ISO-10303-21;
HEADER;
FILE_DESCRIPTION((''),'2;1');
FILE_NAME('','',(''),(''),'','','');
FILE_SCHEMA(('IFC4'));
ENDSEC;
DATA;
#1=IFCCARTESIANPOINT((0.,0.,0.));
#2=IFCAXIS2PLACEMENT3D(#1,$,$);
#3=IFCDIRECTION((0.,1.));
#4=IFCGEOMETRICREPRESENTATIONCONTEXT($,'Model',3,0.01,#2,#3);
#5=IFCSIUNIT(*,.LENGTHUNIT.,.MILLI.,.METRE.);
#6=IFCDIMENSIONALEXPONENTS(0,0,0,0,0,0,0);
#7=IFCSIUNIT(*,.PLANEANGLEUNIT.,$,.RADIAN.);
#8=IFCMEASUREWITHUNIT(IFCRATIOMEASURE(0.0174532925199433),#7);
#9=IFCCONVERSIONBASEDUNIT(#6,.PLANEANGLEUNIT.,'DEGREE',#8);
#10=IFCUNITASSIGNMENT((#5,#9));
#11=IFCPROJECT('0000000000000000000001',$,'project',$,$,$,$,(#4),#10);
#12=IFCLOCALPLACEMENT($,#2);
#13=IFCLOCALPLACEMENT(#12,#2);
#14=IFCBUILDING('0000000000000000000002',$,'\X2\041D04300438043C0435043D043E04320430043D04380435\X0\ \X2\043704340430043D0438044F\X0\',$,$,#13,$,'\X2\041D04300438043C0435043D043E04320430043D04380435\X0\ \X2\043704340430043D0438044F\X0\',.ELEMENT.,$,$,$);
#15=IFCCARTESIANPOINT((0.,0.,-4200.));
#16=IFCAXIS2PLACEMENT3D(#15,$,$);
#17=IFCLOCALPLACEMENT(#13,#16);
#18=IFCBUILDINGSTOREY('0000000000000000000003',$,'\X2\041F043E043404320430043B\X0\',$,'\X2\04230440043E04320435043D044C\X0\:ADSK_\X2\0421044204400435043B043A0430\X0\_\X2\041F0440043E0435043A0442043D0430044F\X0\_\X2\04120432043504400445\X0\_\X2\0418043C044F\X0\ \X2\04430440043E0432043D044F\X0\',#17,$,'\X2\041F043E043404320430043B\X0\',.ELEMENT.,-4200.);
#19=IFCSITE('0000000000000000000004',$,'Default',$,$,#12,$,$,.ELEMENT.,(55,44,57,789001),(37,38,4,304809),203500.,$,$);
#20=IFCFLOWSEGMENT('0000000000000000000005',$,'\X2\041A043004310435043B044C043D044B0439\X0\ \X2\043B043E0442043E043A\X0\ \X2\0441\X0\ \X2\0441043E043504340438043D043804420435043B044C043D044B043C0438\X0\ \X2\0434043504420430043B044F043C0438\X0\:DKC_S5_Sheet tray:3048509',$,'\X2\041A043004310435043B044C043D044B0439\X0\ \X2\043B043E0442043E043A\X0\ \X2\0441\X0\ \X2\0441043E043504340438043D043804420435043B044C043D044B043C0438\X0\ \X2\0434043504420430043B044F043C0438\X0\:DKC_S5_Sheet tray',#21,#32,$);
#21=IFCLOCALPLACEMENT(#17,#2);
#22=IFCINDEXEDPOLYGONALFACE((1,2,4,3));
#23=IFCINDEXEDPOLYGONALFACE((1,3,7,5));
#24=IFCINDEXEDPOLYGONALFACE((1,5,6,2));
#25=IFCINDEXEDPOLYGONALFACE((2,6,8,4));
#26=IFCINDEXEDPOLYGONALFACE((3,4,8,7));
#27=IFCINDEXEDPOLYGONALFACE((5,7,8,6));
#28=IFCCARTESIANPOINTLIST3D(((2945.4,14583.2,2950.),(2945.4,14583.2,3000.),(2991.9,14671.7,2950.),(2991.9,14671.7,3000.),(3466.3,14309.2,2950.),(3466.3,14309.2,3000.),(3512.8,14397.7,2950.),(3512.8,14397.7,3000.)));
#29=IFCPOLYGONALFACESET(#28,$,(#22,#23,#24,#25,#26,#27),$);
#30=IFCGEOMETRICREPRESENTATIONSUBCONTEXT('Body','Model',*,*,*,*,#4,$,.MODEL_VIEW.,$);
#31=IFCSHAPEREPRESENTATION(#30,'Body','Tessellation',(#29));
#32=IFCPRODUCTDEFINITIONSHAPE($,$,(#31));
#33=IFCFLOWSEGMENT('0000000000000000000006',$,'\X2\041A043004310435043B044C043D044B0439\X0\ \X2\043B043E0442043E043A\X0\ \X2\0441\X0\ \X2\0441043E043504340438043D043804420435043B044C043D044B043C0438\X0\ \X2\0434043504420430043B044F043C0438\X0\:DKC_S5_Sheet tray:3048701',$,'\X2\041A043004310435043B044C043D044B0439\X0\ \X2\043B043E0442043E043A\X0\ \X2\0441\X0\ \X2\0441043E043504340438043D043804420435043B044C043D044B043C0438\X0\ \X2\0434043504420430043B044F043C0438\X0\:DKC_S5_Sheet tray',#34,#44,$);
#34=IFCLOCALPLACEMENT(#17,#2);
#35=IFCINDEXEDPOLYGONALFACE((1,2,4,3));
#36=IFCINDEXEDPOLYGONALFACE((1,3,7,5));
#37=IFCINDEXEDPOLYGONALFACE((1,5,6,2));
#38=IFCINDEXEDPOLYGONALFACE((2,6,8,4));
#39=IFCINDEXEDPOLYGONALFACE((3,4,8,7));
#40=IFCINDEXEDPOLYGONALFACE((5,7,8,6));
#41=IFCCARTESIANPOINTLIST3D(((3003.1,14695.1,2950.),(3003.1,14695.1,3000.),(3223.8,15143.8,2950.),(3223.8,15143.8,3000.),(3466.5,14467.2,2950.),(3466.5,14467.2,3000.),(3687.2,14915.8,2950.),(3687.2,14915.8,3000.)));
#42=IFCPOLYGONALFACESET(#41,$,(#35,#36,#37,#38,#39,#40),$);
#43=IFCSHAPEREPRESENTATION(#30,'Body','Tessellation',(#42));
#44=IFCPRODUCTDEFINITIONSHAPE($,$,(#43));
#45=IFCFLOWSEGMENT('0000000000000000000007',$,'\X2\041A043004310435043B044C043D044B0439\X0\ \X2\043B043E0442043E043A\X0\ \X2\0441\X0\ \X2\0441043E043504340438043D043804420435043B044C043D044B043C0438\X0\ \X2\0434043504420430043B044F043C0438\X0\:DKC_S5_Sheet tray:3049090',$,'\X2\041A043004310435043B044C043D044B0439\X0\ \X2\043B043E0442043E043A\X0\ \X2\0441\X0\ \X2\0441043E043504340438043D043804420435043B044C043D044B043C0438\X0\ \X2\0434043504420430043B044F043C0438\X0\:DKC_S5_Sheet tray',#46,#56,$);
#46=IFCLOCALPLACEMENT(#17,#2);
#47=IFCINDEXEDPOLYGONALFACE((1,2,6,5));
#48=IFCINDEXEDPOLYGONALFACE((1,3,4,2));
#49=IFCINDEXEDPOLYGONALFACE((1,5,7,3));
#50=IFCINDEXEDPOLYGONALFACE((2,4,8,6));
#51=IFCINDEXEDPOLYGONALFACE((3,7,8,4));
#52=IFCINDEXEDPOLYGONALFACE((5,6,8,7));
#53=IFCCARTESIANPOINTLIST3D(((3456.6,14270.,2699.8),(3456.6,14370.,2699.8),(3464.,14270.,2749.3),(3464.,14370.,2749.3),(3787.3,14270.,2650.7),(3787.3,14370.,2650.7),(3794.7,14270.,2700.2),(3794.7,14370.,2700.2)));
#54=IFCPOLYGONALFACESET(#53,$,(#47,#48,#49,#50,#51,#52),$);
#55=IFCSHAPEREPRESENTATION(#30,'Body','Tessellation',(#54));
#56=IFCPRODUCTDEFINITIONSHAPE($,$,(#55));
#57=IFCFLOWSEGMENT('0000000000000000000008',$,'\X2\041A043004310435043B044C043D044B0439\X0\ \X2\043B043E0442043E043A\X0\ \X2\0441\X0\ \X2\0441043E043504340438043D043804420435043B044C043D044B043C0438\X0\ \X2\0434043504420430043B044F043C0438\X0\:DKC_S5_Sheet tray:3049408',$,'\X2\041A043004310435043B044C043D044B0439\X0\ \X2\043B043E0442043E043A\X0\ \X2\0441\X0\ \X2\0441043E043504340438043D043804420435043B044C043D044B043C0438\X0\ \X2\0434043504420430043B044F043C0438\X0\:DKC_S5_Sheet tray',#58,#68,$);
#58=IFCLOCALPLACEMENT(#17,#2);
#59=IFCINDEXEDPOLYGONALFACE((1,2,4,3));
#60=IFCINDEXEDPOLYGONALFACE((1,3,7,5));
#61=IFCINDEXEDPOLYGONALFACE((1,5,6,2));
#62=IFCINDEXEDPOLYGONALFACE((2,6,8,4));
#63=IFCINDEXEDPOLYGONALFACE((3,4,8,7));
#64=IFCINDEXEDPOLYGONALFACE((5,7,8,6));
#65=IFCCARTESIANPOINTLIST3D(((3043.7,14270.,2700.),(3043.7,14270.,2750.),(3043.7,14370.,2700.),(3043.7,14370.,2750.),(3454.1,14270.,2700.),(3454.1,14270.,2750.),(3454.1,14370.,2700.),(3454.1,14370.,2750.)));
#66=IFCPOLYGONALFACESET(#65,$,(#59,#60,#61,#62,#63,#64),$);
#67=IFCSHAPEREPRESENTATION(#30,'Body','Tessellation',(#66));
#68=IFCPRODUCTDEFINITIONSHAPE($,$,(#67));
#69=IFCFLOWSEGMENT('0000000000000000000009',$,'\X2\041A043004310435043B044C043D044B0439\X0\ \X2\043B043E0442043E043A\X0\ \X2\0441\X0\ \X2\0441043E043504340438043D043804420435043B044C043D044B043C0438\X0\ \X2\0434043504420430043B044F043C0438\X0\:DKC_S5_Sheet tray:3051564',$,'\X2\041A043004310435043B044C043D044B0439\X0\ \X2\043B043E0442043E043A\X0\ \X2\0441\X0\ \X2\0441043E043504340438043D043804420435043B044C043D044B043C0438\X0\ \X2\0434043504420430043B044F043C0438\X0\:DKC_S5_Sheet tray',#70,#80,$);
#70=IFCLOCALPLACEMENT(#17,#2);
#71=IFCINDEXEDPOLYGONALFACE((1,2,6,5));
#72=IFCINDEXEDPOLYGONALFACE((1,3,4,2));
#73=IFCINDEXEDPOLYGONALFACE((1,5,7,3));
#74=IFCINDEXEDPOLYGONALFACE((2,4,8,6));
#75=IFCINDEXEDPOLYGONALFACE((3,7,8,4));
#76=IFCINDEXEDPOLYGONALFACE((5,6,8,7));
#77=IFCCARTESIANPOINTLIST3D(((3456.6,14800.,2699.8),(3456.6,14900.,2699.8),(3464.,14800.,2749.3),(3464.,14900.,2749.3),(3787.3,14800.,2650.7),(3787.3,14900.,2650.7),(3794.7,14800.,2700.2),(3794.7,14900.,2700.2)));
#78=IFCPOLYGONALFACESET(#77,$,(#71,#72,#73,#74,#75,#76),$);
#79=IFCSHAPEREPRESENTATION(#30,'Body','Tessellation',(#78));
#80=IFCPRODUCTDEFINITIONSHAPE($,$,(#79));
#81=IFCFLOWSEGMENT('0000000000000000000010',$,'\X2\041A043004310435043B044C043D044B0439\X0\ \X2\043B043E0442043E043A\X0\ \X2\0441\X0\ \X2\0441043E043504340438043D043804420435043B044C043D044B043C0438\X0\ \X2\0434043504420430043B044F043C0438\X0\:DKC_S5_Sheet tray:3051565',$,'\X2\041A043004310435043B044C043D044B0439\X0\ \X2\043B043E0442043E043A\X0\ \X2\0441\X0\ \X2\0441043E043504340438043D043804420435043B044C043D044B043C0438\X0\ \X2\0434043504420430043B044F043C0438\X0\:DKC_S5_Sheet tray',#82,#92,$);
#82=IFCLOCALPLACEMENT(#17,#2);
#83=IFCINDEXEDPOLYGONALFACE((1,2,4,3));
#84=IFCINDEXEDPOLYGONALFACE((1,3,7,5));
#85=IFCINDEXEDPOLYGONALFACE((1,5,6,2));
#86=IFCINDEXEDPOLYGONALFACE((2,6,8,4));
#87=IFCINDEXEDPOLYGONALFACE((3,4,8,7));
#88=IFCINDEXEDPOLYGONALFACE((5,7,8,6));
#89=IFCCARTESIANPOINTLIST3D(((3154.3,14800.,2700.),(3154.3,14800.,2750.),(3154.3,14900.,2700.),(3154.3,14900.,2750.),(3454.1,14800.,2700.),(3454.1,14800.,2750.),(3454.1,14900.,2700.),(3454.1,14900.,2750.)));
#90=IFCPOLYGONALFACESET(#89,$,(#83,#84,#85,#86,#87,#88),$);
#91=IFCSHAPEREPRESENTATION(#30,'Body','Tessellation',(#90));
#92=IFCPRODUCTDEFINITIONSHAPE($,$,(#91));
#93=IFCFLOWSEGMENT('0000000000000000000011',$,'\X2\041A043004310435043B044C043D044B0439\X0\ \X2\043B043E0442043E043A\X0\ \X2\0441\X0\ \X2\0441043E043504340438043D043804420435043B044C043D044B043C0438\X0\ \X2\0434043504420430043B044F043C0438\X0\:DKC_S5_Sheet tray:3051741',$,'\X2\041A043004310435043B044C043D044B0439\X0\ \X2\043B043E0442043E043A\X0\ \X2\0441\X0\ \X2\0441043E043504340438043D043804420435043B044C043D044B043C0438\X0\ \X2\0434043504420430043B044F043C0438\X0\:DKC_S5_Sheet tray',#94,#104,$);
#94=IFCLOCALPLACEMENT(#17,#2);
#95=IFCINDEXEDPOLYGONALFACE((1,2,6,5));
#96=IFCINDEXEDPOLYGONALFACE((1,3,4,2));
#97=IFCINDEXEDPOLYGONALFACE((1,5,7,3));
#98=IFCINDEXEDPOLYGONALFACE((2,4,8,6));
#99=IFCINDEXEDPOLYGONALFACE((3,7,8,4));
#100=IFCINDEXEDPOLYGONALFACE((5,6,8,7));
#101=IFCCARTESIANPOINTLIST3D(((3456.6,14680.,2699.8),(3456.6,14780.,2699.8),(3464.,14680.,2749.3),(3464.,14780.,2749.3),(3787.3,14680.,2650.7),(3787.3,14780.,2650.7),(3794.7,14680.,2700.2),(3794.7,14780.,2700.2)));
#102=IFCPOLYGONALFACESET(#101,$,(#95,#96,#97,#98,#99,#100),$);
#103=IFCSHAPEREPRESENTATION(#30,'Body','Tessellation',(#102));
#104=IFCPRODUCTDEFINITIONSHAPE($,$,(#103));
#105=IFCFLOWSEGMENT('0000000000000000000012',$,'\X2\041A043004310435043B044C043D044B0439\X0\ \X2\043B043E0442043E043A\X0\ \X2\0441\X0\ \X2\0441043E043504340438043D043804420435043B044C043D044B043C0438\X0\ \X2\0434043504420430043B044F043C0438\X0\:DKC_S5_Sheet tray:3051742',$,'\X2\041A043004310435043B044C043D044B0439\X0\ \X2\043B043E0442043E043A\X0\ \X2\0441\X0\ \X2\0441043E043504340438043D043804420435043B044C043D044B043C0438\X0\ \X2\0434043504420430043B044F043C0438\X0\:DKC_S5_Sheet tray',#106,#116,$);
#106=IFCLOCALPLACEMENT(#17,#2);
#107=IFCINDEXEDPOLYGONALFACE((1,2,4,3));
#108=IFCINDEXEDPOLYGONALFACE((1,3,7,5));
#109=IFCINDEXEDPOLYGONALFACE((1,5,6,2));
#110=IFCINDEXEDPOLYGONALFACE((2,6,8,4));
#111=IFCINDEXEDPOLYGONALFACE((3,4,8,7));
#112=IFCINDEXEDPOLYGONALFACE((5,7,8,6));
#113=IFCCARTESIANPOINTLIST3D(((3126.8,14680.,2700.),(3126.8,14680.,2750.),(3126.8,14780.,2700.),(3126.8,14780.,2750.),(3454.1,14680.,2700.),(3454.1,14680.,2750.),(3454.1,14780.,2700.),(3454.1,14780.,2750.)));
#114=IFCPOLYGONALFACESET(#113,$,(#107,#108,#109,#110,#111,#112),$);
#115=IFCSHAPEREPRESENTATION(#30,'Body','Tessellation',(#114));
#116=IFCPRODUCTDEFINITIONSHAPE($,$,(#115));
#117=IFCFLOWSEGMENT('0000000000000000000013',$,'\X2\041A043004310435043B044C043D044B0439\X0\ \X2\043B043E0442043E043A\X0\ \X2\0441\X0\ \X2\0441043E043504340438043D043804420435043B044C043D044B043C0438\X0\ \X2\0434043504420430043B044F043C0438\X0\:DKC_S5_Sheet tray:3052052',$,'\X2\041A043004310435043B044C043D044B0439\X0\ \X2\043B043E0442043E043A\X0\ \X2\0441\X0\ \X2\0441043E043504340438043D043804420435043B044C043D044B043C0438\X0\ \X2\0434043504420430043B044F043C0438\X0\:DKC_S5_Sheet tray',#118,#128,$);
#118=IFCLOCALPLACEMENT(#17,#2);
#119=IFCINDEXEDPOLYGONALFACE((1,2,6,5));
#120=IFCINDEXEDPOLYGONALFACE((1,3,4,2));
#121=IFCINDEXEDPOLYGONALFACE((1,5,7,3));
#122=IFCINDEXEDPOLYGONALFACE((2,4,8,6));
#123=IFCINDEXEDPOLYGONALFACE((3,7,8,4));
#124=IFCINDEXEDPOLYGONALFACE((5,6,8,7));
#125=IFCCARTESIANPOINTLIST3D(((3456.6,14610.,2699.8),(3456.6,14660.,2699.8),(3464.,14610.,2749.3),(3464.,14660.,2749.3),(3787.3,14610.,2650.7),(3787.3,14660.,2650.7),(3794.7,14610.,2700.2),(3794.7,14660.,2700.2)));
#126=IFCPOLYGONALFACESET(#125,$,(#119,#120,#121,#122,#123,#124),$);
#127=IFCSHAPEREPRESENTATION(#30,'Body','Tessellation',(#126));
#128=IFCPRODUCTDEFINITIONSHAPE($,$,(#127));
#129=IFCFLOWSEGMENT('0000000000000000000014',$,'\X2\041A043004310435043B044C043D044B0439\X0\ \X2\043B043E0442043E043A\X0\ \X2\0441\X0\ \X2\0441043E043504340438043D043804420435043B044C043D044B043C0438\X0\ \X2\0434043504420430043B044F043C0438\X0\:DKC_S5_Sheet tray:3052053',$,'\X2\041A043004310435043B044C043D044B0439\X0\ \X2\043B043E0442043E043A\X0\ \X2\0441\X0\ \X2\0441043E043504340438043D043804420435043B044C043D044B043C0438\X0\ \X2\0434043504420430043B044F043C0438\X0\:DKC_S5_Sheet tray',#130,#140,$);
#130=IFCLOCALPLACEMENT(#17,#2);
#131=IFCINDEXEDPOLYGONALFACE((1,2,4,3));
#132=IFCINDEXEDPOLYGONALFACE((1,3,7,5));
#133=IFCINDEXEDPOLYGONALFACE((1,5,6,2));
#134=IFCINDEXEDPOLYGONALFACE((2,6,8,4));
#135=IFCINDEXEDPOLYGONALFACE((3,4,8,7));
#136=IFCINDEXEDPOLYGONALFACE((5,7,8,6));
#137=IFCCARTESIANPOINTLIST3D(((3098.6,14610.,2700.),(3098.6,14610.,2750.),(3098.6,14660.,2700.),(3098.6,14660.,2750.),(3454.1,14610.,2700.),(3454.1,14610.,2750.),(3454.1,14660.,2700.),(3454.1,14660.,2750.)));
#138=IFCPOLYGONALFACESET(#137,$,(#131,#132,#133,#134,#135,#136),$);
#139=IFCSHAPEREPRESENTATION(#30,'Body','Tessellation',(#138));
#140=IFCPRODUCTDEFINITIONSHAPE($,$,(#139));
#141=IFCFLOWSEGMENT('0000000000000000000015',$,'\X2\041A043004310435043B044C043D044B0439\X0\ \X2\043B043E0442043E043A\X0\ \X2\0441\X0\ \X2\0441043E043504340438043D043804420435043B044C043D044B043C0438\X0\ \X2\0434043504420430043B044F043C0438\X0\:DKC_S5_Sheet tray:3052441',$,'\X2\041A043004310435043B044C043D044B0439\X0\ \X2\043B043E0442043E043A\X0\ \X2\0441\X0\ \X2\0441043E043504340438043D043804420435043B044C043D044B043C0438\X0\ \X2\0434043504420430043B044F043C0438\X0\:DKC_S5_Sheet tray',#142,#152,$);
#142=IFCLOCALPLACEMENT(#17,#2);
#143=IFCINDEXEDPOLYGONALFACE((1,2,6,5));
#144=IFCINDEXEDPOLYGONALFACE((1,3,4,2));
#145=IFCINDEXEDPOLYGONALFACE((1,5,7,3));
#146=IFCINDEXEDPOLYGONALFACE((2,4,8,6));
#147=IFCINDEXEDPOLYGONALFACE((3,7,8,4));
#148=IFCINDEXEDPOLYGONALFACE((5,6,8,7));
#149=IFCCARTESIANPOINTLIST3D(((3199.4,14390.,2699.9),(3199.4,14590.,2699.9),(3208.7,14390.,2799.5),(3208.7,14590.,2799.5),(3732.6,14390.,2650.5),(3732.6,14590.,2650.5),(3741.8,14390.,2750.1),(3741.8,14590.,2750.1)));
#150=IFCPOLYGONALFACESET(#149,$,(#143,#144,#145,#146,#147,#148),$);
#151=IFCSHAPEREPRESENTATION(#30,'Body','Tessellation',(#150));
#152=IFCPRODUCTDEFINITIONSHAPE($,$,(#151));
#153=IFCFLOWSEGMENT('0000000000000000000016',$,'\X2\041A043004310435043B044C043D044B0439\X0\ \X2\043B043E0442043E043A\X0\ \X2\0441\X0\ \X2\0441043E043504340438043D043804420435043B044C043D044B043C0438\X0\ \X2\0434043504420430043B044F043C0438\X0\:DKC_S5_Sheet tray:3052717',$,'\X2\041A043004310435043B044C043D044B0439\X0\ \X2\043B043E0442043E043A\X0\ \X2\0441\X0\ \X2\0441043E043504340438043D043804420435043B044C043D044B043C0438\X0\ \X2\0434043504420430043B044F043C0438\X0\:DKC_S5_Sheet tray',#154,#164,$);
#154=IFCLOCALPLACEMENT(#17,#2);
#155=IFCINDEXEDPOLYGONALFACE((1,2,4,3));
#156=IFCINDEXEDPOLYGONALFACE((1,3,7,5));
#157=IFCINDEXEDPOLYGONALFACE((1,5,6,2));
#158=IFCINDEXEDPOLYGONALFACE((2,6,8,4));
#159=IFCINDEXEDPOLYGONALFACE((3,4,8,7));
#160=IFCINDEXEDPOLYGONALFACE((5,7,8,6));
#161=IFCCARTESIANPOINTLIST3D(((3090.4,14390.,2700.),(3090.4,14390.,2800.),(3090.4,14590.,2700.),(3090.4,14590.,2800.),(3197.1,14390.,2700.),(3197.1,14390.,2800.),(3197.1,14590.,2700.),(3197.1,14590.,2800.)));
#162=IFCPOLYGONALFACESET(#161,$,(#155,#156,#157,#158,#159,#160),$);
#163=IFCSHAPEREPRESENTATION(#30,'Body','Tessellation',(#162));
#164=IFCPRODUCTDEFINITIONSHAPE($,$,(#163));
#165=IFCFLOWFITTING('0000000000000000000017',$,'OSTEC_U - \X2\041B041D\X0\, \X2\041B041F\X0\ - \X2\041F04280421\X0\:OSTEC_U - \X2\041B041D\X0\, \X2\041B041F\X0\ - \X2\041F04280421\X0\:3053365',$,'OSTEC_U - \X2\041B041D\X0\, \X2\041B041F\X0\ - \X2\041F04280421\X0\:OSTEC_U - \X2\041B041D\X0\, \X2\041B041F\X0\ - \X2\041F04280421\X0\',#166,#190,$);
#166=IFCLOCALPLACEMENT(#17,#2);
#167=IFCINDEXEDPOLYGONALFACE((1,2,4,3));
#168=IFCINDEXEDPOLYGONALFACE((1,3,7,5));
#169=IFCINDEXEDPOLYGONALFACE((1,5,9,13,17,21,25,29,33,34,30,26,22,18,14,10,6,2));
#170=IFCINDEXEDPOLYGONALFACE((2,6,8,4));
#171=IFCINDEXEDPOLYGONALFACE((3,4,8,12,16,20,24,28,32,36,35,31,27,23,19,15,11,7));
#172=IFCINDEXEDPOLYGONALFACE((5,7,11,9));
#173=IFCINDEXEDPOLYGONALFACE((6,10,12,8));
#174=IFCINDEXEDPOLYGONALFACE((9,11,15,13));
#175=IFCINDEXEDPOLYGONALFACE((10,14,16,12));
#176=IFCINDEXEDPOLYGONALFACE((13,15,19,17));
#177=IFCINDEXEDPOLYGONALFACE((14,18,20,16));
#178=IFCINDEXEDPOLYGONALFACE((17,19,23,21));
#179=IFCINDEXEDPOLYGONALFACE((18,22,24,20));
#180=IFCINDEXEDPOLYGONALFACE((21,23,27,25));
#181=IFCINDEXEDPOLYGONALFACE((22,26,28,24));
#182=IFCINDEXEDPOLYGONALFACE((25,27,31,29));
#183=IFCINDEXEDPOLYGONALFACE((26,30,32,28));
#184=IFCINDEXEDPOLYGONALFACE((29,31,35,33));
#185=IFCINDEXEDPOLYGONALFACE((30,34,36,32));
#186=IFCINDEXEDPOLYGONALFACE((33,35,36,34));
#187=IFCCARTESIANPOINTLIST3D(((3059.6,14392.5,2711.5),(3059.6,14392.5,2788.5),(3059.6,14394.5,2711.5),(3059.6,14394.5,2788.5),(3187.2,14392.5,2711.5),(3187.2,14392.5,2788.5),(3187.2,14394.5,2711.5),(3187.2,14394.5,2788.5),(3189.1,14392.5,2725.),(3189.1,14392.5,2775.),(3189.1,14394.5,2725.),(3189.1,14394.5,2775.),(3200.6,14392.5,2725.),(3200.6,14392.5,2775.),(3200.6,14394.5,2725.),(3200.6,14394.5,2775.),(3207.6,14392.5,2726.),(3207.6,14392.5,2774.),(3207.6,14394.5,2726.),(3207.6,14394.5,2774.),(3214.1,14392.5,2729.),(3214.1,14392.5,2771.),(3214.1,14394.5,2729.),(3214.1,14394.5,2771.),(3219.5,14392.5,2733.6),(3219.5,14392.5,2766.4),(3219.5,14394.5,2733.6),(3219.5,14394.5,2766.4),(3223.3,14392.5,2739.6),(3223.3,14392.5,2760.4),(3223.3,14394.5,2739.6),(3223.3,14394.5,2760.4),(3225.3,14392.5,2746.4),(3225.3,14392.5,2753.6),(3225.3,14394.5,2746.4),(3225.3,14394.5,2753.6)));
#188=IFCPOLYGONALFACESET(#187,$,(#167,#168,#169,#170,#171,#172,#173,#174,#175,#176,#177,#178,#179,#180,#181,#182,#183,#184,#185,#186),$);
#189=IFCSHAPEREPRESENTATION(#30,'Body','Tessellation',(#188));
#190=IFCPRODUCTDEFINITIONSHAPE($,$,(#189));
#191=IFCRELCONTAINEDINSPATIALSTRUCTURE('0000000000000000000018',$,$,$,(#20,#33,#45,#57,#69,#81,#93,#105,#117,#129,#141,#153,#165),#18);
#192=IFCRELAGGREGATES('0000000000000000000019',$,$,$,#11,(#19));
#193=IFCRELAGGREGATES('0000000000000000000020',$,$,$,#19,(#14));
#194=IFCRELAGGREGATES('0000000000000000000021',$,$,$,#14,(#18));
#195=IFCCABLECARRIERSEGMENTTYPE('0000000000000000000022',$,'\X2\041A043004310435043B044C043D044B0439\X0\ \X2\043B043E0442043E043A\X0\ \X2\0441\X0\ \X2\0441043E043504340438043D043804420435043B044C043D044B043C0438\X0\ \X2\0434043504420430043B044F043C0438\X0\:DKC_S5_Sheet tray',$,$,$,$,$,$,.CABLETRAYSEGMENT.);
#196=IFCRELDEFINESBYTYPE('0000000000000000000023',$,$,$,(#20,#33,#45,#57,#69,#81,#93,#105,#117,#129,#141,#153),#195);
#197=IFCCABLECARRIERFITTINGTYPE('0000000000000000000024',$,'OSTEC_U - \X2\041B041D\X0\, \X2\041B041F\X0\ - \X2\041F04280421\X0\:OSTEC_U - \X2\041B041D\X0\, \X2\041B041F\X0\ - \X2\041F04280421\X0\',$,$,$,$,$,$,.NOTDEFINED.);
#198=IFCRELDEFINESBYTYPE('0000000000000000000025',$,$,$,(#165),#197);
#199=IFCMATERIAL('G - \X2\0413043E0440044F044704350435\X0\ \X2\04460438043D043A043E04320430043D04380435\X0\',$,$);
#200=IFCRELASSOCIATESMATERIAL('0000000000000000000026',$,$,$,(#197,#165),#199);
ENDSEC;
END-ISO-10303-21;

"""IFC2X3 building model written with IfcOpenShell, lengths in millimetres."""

from ifc_helpers import new_model, entity, si_unit, converted_unit, direction, frame, frame_2d, origin, origin_2d_with_axis, place, context, subcontext, project, spatial, polyline, circle_curve, parameter, trimmed, segment, composite_curve, rectangle, outline, extrude, source, transform, mapped, material, type_object, type_shapes, element, save


model = new_model("IFC2X3")

# Units and contexts
model_context = context("Model", 3, precision=0.01, world=origin(), true_north=direction((0.0, 1.0)))
body_context = subcontext(model_context, "Body", "Model", "MODEL_VIEW")
ifc_project = project(units=[si_unit("LENGTHUNIT", "METRE", prefix="MILLI"), converted_unit("PLANEANGLEUNIT", "DEGREE", entity("IfcRatioMeasure", 0.0174532925199433), si_unit("PLANEANGLEUNIT", "RADIAN"), dimensions=[0, 0, 0, 0, 0, 0, 0])], contexts=[model_context])

# Site, building, storey
site_placement = place(None, frame((0.0, 0.0, 0.0)))
site = spatial("IfcSite", under=ifc_project, at=site_placement, Name="Default", CompositionType="ELEMENT", RefLatitude=(55, 44, 57, 789001), RefLongitude=(37, 38, 4, 304809), RefElevation=203500.0)
building_placement = place(site_placement, origin())
building = spatial("IfcBuilding", under=site, at=building_placement, Name="Наименование здания", LongName="Наименование здания", CompositionType="ELEMENT")
storey_placement = place(building_placement, frame((0.0, 0.0, -4200.0)))
storey = spatial("IfcBuildingStorey", under=building, at=storey_placement, Name="Подвал", ObjectType="Уровень:ADSK_Стрелка_Проектная_Вверх_Имя уровня", LongName="Подвал", CompositionType="ELEMENT", Elevation=-4200.0)

# Flow segments
cable_carrier_segment_type = type_object("IfcCableCarrierSegmentType", Name="Кабельный лоток с соединительными деталями:DKC_S5_Sheet tray", PredefinedType="CABLETRAYSEGMENT")
flow_segment_1_placement = place(storey_placement, frame((2945.4, 14309.2, 2950.0)))
element("IfcFlowSegment", 1, at=flow_segment_1_placement, inside=storey, type_object=cable_carrier_segment_type, Name="Кабельный лоток с соединительными деталями:DKC_S5_Sheet tray:3048509", ObjectType="Кабельный лоток с соединительными деталями:DKC_S5_Sheet tray", context=body_context, shape_type="SweptSolid", body=[
    extrude(rectangle(XDim=588.6, YDim=100.0, at=frame_2d((0.0, 0.0), x_axis=(1.0, 0.0))), frame((283.7, 181.3, 0.0), z_axis=(0.0, 0.0, 1.0), x_axis=(0.885007, -0.465578, 0.0)), (0.0, 0.0, 1.0), 50.0),
])
flow_segment_2_placement = place(storey_placement, frame((3003.1, 14467.2, 2950.0)))
element("IfcFlowSegment", 2, at=flow_segment_2_placement, inside=storey, type_object=cable_carrier_segment_type, Name="Кабельный лоток с соединительными деталями:DKC_S5_Sheet tray:3048701", ObjectType="Кабельный лоток с соединительными деталями:DKC_S5_Sheet tray", context=body_context, shape_type="SweptSolid", body=[
    extrude(rectangle(XDim=516.5, YDim=500.0, at=origin_2d_with_axis()), frame((342.1, 338.3, 0.0), z_axis=(0.0, 0.0, 1.0), x_axis=(0.897336, -0.441348, 0.0)), (0.0, 0.0, 1.0), 50.0),
])
flow_segment_3_placement = place(storey_placement, frame((3456.6, 14270.0, 2650.7)))
element("IfcFlowSegment", 3, at=flow_segment_3_placement, inside=storey, type_object=cable_carrier_segment_type, Name="Кабельный лоток с соединительными деталями:DKC_S5_Sheet tray:3049090", ObjectType="Кабельный лоток с соединительными деталями:DKC_S5_Sheet tray", context=body_context, shape_type="SweptSolid", body=[
    extrude(rectangle(XDim=50.0, YDim=100.0, at=origin_2d_with_axis()), frame((3.7, 50.0, 73.8), z_axis=(0.989166, 0.0, -0.1468), x_axis=(0.1468, 0.0, 0.989166)), (0.0, 0.0, 1.0), 334.3),
])
flow_segment_4_placement = place(storey_placement, frame((3043.7, 14270.0, 2700.0)))
element("IfcFlowSegment", 4, at=flow_segment_4_placement, inside=storey, type_object=cable_carrier_segment_type, Name="Кабельный лоток с соединительными деталями:DKC_S5_Sheet tray:3049408", ObjectType="Кабельный лоток с соединительными деталями:DKC_S5_Sheet tray", context=body_context, shape_type="SweptSolid", body=[
    extrude(rectangle(XDim=410.3, YDim=100.0, at=frame_2d((0.0, 0.0), x_axis=(1.0, 0.0))), frame((205.2, 50.0, 0.0), z_axis=(0.0, 0.0, 1.0), x_axis=(-1.0, 0.0, 0.0)), (0.0, 0.0, 1.0), 50.0),
])
flow_segment_5_placement = place(storey_placement, frame((3456.6, 14800.0, 2650.7)))
element("IfcFlowSegment", 5, at=flow_segment_5_placement, inside=storey, type_object=cable_carrier_segment_type, Name="Кабельный лоток с соединительными деталями:DKC_S5_Sheet tray:3051564", ObjectType="Кабельный лоток с соединительными деталями:DKC_S5_Sheet tray", context=body_context, shape_type="SweptSolid", body=[
    extrude(rectangle(XDim=50.0, YDim=100.0, at=origin_2d_with_axis()), frame((3.7, 50.0, 73.8), z_axis=(0.989166, 0.0, -0.1468), x_axis=(0.1468, 0.0, 0.989166)), (0.0, 0.0, 1.0), 334.3),
])
flow_segment_6_placement = place(storey_placement, frame((3154.3, 14800.0, 2700.0)))
element("IfcFlowSegment", 6, at=flow_segment_6_placement, inside=storey, type_object=cable_carrier_segment_type, Name="Кабельный лоток с соединительными деталями:DKC_S5_Sheet tray:3051565", ObjectType="Кабельный лоток с соединительными деталями:DKC_S5_Sheet tray", context=body_context, shape_type="SweptSolid", body=[
    extrude(rectangle(XDim=299.7, YDim=100.0, at=frame_2d((0.0, 0.0), x_axis=(1.0, 0.0))), frame((149.9, 50.0, 0.0), z_axis=(0.0, 0.0, 1.0), x_axis=(-1.0, 0.0, 0.0)), (0.0, 0.0, 1.0), 50.0),
])
flow_segment_7_placement = place(storey_placement, frame((3456.6, 14680.0, 2650.7)))
element("IfcFlowSegment", 7, at=flow_segment_7_placement, inside=storey, type_object=cable_carrier_segment_type, Name="Кабельный лоток с соединительными деталями:DKC_S5_Sheet tray:3051741", ObjectType="Кабельный лоток с соединительными деталями:DKC_S5_Sheet tray", context=body_context, shape_type="SweptSolid", body=[
    extrude(rectangle(XDim=50.0, YDim=100.0, at=origin_2d_with_axis()), frame((3.7, 50.0, 73.8), z_axis=(0.989166, 0.0, -0.1468), x_axis=(0.1468, 0.0, 0.989166)), (0.0, 0.0, 1.0), 334.3),
])
flow_segment_8_placement = place(storey_placement, frame((3126.8, 14680.0, 2700.0)))
element("IfcFlowSegment", 8, at=flow_segment_8_placement, inside=storey, type_object=cable_carrier_segment_type, Name="Кабельный лоток с соединительными деталями:DKC_S5_Sheet tray:3051742", ObjectType="Кабельный лоток с соединительными деталями:DKC_S5_Sheet tray", context=body_context, shape_type="SweptSolid", body=[
    extrude(rectangle(XDim=327.2, YDim=100.0, at=frame_2d((0.0, 0.0), x_axis=(1.0, 0.0))), frame((163.6, 50.0, 0.0), z_axis=(0.0, 0.0, 1.0), x_axis=(-1.0, 0.0, 0.0)), (0.0, 0.0, 1.0), 50.0),
])
flow_segment_9_placement = place(storey_placement, frame((3456.6, 14610.0, 2650.7)))
element("IfcFlowSegment", 9, at=flow_segment_9_placement, inside=storey, type_object=cable_carrier_segment_type, Name="Кабельный лоток с соединительными деталями:DKC_S5_Sheet tray:3052052", ObjectType="Кабельный лоток с соединительными деталями:DKC_S5_Sheet tray", context=body_context, shape_type="SweptSolid", body=[
    extrude(rectangle(XDim=50.0, YDim=50.0, at=frame_2d((0.0, 0.0), x_axis=(1.0, 0.0))), frame((3.7, 25.0, 73.8), z_axis=(0.989166, 0.0, -0.1468), x_axis=(0.1468, 0.0, 0.989166)), (0.0, 0.0, 1.0), 334.3),
])
flow_segment_10_placement = place(storey_placement, frame((3098.6, 14610.0, 2700.0)))
element("IfcFlowSegment", 10, at=flow_segment_10_placement, inside=storey, type_object=cable_carrier_segment_type, Name="Кабельный лоток с соединительными деталями:DKC_S5_Sheet tray:3052053", ObjectType="Кабельный лоток с соединительными деталями:DKC_S5_Sheet tray", context=body_context, shape_type="SweptSolid", body=[
    extrude(rectangle(XDim=355.5, YDim=50.0, at=frame_2d((0.0, 0.0), x_axis=(1.0, 0.0))), frame((177.7, 25.0, 0.0), z_axis=(0.0, 0.0, 1.0), x_axis=(-1.0, 0.0, 0.0)), (0.0, 0.0, 1.0), 50.0),
])
flow_segment_11_placement = place(storey_placement, frame((3199.4, 14390.0, 2650.5)))
element("IfcFlowSegment", 11, at=flow_segment_11_placement, inside=storey, type_object=cable_carrier_segment_type, Name="Кабельный лоток с соединительными деталями:DKC_S5_Sheet tray:3052441", ObjectType="Кабельный лоток с соединительными деталями:DKC_S5_Sheet tray", context=body_context, shape_type="SweptSolid", body=[
    extrude(rectangle(XDim=100.0, YDim=200.0, at=origin_2d_with_axis()), frame((4.6, 100.0, 99.1), z_axis=(0.995742, 0.0, -0.092183), x_axis=(0.092183, 0.0, 0.995742)), (0.0, 0.0, 1.0), 535.4),
])
flow_segment_12_placement = place(storey_placement, frame((3090.4, 14390.0, 2700.0)))
element("IfcFlowSegment", 12, at=flow_segment_12_placement, inside=storey, type_object=cable_carrier_segment_type, Name="Кабельный лоток с соединительными деталями:DKC_S5_Sheet tray:3052717", ObjectType="Кабельный лоток с соединительными деталями:DKC_S5_Sheet tray", context=body_context, shape_type="SweptSolid", body=[
    extrude(rectangle(XDim=106.6, YDim=200.0, at=frame_2d((0.0, 0.0), x_axis=(1.0, 0.0))), frame((53.3, 100.0, 0.0), z_axis=(0.0, 0.0, 1.0), x_axis=(-1.0, 0.0, 0.0)), (0.0, 0.0, 1.0), 100.0),
])

# Flow fitting
ifc_material_1 = material(Name="G - Горячее цинкование")
cable_carrier_fitting_type_1 = type_object("IfcCableCarrierFittingType", Name="OSTEC_U - ЛН, ЛП - ПШС:OSTEC_U - ЛН, ЛП - ПШС", PredefinedType="NOTDEFINED", material=ifc_material_1)
shared_shape_1 = source(origin(), body_context, "Body", "SweptSolid", [
    extrude(outline(composite_curve([segment(trimmed(circle_curve(frame_2d((-41.5, 0.0), x_axis=(1.0, 0.0)), 25.0), [parameter(90.0)], [parameter(270.0)], True, "PARAMETER"), True, "CONTINUOUS"), segment(polyline([(-41.5, -25.0), (-30.0, -25.0)]), True, "CONTINUOUS"), segment(polyline([(-30.0, -25.0), (-28.1, -38.5)]), True, "CONTINUOUS"), segment(polyline([(-28.1, -38.5), (99.5, -38.5)]), True, "CONTINUOUS"), segment(polyline([(99.5, -38.5), (99.5, 38.5)]), True, "CONTINUOUS"), segment(polyline([(99.5, 38.5), (-28.1, 38.5)]), True, "CONTINUOUS"), segment(polyline([(-28.1, 38.5), (-30.0, 25.0)]), True, "CONTINUOUS"), segment(polyline([(-30.0, 25.0), (-41.5, 25.0)]), True, "CONTINUOUS")], self_intersect=False)), frame((41.5, 0.0, 0.0), z_axis=(0.0, 0.0, -1.0), x_axis=(1.0, 0.0, 0.0)), (0.0, 0.0, -1.0), 2.0),
])
type_shapes(cable_carrier_fitting_type_1, [shared_shape_1])
flow_fitting_1_placement = place(storey_placement, frame((3200.6, 14394.5, 2750.0), z_axis=(0.0, -1.0, 0.0), x_axis=(-1.0, 0.0, 0.0)))
element("IfcFlowFitting", 13, at=flow_fitting_1_placement, inside=storey, type_object=cable_carrier_fitting_type_1, material=ifc_material_1, Name="OSTEC_U - ЛН, ЛП - ПШС:OSTEC_U - ЛН, ЛП - ПШС:3053365", ObjectType="OSTEC_U - ЛН, ЛП - ПШС:OSTEC_U - ЛН, ЛП - ПШС", context=body_context, shape_type="MappedRepresentation", body=[
    mapped(shared_shape_1, transform((0.0, 0.0, 0.0), scale=1.0)),
])

save(model, "model.ifc")
